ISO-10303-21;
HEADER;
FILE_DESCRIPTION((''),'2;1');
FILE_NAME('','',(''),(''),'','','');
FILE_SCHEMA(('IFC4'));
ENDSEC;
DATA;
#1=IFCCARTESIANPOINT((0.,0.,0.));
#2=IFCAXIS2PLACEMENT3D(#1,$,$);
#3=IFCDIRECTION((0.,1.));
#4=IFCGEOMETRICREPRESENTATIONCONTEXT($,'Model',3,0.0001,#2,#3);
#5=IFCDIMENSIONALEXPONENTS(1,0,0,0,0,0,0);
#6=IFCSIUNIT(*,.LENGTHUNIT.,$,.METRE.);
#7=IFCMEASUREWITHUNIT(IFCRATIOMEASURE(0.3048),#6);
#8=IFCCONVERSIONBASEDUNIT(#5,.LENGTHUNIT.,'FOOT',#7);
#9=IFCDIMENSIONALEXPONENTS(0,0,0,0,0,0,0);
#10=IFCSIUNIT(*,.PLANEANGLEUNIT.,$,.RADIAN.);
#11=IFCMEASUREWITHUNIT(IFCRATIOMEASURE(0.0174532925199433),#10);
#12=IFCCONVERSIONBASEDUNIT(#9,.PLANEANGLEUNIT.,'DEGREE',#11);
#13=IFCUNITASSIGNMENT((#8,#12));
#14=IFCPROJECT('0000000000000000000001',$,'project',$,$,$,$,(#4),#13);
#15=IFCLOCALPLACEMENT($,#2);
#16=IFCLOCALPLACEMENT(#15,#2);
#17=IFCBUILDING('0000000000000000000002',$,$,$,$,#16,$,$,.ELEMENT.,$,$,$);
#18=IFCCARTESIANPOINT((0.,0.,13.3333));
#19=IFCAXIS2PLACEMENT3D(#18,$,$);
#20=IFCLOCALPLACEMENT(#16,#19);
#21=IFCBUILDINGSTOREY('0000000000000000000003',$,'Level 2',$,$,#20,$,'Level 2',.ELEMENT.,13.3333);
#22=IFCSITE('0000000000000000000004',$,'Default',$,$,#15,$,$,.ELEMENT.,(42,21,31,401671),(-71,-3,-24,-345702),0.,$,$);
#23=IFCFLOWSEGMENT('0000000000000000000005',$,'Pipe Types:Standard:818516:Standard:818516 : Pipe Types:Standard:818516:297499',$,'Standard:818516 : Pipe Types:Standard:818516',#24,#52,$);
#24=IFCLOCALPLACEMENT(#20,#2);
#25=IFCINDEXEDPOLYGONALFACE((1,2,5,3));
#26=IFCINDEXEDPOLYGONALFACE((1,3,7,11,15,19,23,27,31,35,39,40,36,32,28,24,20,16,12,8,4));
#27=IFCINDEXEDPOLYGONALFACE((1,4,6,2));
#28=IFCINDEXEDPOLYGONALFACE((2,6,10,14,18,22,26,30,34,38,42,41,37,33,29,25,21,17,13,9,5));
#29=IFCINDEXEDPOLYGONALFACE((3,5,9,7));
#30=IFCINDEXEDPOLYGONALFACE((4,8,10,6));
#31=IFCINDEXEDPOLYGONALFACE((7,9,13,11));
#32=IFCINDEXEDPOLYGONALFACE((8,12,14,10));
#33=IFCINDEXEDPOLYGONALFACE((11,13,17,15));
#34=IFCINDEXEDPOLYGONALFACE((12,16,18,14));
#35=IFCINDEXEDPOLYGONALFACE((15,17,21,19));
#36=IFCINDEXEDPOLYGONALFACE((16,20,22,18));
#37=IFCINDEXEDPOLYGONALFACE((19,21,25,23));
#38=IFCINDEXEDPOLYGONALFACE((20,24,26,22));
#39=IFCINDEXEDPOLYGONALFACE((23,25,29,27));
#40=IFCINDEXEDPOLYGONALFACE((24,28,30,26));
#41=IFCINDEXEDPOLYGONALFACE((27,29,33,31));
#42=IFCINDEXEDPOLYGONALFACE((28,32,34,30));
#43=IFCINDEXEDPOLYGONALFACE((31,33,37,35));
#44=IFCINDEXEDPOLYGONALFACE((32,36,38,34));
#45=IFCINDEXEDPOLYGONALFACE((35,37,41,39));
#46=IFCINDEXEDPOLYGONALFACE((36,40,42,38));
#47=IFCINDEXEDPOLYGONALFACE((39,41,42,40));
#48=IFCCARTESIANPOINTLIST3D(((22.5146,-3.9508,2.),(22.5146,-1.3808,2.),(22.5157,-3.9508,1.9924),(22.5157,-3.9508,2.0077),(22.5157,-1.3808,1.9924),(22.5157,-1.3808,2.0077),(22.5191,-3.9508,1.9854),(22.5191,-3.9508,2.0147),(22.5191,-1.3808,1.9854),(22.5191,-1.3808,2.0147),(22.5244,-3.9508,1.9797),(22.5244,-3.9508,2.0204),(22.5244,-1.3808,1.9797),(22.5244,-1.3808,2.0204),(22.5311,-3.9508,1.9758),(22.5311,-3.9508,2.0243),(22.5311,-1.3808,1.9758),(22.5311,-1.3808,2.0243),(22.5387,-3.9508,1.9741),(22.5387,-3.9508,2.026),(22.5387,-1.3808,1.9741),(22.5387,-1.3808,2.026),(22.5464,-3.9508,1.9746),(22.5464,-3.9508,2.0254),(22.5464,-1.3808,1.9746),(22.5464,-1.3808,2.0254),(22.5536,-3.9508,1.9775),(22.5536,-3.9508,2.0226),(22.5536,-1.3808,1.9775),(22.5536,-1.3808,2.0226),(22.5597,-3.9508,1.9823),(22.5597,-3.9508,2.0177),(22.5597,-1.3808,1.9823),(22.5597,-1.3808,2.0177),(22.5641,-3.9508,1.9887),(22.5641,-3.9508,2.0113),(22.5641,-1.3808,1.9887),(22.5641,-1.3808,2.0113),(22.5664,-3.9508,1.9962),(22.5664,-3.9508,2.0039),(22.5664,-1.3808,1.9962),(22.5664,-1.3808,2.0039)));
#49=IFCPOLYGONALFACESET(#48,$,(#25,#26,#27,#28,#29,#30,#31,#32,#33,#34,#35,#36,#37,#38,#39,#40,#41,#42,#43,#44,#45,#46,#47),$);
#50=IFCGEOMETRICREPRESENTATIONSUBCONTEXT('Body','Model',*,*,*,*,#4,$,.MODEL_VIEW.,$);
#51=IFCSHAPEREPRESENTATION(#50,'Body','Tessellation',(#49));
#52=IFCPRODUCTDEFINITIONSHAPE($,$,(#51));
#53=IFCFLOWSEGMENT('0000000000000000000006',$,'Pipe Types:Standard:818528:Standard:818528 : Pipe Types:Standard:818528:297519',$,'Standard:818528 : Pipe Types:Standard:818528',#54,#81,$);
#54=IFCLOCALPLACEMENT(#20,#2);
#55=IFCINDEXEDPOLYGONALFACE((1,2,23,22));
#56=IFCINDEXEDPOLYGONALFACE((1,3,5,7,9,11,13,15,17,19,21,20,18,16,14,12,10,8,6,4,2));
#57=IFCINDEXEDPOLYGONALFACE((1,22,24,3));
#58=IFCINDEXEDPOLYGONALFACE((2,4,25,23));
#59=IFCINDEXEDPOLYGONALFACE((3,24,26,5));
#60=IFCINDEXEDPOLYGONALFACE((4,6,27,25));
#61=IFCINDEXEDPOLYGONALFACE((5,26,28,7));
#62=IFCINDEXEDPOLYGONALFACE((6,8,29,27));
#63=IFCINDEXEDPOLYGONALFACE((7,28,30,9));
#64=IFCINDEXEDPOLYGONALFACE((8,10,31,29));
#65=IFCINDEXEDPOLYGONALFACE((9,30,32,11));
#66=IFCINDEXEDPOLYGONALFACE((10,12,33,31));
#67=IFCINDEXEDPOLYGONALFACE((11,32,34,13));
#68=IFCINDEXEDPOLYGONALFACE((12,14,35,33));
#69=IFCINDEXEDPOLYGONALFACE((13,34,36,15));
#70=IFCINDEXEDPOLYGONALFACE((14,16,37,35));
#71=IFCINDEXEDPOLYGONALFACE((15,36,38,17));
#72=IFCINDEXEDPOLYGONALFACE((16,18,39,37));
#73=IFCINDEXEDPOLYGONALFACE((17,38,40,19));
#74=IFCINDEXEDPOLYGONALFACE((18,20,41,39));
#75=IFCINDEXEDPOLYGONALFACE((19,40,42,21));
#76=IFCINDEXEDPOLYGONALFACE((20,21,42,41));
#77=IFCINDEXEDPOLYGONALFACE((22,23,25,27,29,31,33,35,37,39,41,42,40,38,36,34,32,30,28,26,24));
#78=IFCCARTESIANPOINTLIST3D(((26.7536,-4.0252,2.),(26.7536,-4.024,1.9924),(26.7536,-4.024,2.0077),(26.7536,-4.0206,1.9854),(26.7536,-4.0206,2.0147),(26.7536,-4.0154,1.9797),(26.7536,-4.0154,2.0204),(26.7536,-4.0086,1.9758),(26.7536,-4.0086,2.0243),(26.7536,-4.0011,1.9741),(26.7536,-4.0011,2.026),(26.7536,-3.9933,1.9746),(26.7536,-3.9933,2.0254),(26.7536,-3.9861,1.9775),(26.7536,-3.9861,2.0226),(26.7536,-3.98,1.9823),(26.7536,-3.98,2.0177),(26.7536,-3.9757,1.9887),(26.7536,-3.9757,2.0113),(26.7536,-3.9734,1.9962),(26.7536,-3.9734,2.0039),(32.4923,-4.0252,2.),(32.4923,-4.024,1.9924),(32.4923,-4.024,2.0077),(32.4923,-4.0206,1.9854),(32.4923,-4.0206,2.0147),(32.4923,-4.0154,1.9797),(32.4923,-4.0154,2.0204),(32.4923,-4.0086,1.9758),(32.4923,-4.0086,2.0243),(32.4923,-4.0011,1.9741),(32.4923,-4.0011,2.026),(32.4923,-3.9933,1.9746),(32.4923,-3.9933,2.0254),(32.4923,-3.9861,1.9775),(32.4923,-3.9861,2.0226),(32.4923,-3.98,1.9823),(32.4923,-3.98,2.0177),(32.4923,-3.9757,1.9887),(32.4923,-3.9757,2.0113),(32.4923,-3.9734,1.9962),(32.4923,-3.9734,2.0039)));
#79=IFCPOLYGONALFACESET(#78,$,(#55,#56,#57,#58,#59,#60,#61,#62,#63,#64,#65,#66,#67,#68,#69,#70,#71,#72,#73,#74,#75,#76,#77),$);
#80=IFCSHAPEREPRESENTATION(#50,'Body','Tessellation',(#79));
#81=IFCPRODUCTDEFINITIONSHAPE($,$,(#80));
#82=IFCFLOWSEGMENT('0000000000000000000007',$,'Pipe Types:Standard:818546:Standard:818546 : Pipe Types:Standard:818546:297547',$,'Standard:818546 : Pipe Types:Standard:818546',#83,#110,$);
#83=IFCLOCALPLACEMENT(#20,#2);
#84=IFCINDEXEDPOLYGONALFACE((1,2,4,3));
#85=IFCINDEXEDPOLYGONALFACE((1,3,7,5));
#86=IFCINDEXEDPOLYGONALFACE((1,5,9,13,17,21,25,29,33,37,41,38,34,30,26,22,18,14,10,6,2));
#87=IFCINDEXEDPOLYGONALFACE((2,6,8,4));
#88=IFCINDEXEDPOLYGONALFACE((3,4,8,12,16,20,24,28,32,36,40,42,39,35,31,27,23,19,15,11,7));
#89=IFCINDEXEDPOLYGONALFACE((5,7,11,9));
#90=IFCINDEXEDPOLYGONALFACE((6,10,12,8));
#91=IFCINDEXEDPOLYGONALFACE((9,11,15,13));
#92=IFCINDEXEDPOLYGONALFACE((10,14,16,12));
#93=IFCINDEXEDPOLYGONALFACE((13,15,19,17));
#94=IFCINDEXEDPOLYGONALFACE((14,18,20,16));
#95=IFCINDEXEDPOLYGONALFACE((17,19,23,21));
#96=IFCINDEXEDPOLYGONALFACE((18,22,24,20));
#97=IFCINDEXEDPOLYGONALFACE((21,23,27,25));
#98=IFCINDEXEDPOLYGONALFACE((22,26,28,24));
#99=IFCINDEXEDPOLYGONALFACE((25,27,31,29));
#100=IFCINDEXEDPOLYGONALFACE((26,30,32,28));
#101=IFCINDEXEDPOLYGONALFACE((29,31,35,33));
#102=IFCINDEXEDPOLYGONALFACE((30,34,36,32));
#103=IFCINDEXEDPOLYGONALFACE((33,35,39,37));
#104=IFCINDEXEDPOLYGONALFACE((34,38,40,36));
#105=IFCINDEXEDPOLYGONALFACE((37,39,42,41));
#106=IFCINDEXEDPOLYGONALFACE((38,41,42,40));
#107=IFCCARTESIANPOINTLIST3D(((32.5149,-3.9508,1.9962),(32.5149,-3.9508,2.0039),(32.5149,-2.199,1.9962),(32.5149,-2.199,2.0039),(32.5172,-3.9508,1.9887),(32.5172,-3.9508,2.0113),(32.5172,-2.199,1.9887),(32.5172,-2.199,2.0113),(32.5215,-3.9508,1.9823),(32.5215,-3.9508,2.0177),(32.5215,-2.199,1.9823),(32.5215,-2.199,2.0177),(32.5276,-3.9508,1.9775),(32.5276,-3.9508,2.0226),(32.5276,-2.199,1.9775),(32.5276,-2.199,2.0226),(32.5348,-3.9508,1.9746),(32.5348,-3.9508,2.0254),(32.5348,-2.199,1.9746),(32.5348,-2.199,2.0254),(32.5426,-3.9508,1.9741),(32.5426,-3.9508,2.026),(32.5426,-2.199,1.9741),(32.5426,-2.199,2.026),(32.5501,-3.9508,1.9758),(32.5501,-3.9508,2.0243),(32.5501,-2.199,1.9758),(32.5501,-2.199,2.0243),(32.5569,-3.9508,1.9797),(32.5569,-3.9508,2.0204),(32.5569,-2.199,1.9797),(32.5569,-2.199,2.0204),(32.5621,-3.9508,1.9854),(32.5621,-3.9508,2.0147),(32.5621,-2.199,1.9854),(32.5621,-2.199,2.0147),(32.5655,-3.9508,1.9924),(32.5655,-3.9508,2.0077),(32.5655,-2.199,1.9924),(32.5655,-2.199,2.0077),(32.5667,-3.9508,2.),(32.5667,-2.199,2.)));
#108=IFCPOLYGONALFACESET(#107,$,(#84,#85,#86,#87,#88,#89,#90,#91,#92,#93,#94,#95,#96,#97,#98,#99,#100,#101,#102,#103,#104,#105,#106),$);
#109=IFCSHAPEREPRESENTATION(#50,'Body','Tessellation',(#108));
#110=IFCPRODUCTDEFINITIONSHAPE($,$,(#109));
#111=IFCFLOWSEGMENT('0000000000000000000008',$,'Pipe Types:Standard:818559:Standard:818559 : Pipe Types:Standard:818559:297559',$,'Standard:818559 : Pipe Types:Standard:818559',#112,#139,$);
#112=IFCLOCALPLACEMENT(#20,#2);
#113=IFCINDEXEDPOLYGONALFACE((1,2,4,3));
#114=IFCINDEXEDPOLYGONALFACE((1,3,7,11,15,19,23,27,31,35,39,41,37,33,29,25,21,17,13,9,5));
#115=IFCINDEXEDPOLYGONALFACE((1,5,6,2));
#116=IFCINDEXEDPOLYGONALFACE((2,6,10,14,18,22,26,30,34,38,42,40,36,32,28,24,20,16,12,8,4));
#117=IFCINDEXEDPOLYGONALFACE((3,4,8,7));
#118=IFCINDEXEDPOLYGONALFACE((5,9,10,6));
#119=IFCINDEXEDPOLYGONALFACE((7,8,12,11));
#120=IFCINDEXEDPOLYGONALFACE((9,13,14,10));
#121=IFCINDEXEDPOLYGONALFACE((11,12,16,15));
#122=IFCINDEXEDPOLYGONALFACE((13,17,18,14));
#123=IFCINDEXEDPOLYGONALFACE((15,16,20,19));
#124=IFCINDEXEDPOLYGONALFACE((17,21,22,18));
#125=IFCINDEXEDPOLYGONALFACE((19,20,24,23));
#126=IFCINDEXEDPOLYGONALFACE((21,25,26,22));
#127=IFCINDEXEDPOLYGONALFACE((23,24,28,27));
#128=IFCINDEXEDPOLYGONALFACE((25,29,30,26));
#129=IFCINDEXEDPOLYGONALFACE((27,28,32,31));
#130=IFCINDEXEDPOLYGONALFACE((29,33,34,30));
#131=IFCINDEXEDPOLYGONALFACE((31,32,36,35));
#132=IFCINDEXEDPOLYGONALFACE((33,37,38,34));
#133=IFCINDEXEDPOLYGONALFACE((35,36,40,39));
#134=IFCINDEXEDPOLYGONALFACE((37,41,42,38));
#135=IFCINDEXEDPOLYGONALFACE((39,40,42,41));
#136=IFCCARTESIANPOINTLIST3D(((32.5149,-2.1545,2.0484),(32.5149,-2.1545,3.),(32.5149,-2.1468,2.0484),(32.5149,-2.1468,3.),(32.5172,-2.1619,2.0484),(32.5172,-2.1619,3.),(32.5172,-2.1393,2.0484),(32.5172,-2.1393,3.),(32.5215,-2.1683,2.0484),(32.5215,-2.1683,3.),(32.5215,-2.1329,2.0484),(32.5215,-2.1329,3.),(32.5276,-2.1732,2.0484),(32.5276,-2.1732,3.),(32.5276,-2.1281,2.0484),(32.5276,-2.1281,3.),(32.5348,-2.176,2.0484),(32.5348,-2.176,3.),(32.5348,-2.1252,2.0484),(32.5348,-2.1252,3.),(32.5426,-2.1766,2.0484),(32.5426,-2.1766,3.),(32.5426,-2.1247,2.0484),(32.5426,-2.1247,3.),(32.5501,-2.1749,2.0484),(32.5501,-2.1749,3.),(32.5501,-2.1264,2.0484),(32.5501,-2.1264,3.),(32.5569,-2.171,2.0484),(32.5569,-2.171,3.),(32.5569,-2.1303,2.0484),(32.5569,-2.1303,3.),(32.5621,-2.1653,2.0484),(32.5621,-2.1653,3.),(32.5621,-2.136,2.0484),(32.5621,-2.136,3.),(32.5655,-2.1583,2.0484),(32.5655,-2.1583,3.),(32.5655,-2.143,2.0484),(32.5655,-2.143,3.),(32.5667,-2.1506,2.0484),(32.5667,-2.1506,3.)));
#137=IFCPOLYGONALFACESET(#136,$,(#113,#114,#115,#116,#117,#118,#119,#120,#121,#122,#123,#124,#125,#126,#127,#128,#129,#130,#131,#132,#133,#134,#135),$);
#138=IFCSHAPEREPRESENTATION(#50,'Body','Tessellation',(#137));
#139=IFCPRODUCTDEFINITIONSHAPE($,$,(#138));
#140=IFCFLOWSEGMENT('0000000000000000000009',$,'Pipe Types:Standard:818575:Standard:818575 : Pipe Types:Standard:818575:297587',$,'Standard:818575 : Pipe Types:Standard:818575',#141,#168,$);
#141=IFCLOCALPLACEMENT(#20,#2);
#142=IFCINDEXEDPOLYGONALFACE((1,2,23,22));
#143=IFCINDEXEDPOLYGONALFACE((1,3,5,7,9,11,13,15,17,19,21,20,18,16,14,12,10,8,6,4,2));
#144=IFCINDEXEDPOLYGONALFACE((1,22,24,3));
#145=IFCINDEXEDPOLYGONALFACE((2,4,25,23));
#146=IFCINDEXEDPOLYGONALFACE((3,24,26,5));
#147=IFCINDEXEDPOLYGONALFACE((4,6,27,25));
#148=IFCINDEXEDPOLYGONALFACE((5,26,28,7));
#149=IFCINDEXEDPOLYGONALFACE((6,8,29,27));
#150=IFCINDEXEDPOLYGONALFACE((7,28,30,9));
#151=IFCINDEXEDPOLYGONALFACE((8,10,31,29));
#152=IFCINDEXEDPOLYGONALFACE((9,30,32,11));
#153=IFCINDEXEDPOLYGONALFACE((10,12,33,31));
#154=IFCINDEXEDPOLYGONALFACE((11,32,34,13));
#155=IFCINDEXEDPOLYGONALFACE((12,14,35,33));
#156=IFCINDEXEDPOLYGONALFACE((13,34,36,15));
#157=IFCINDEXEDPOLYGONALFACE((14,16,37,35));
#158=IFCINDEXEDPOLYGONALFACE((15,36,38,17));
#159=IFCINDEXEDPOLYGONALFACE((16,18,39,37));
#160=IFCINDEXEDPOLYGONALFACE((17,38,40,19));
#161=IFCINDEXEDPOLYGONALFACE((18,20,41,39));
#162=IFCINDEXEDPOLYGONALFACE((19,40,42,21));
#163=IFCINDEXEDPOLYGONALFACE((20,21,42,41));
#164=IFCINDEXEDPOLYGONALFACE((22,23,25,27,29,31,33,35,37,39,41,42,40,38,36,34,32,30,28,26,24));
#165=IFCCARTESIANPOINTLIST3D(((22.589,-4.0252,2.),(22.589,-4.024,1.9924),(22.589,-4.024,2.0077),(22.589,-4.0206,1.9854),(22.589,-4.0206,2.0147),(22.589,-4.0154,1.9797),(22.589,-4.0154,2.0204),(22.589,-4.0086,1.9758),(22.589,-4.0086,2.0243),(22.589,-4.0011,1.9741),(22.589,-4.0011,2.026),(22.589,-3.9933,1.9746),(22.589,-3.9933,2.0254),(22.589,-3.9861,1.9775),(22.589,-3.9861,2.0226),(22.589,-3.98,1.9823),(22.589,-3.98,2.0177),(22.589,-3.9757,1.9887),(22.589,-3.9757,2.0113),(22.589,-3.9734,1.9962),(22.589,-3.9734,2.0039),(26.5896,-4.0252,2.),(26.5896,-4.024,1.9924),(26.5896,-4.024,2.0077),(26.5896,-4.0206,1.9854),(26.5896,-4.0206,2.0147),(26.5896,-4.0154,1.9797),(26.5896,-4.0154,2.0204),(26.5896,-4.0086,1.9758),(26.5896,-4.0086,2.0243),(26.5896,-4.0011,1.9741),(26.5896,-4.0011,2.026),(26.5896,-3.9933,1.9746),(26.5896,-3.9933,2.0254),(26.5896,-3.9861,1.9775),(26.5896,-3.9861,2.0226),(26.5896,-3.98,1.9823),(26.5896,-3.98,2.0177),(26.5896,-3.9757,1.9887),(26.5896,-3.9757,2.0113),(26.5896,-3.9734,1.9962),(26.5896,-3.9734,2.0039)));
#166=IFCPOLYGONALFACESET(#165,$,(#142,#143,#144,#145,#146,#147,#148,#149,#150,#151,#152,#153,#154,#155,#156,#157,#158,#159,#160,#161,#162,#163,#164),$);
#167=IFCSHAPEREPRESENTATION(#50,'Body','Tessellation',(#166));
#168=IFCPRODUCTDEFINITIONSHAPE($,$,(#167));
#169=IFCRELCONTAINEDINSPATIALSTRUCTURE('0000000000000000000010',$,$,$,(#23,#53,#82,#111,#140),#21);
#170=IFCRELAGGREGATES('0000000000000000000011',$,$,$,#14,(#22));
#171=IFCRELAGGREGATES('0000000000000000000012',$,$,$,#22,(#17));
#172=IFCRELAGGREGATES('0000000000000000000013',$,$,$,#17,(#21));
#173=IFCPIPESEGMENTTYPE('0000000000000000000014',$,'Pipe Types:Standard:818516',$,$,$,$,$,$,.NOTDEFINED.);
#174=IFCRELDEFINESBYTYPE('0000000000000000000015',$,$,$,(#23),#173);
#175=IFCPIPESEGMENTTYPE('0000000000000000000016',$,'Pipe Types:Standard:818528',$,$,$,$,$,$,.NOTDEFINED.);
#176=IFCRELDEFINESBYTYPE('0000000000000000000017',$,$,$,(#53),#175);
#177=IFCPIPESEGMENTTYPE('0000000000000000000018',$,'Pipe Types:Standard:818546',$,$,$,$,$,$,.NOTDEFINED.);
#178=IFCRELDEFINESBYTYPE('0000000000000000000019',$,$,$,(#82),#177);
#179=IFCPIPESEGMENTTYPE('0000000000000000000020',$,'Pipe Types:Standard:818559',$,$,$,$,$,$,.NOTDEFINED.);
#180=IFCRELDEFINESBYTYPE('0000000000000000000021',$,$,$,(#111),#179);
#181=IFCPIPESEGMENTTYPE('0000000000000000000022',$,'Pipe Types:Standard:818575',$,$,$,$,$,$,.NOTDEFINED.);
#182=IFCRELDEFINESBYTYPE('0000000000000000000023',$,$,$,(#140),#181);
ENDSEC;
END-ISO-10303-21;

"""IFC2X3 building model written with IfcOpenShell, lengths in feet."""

from ifc_helpers import new_model, entity, si_unit, converted_unit, direction, frame, origin, origin_2d_with_axis, place, context, subcontext, project, spatial, circle, extrude, source, transform, mapped, type_object, type_shapes, element, save


model = new_model("IFC2X3")

# Units and contexts
model_context = context("Model", 3, precision=0.0001, world=origin(), true_north=direction((0.0, 1.0)))
body_context = subcontext(model_context, "Body", "Model", "MODEL_VIEW")
ifc_project = project(units=[converted_unit("LENGTHUNIT", "FOOT", entity("IfcRatioMeasure", 0.3048), si_unit("LENGTHUNIT", "METRE"), dimensions=[1, 0, 0, 0, 0, 0, 0]), converted_unit("PLANEANGLEUNIT", "DEGREE", entity("IfcRatioMeasure", 0.0174532925199433), si_unit("PLANEANGLEUNIT", "RADIAN"), dimensions=[0, 0, 0, 0, 0, 0, 0])], contexts=[model_context])

# Site, building, storey
site_placement = place(None, origin())
site = spatial("IfcSite", under=ifc_project, at=site_placement, Name="Default", CompositionType="ELEMENT", RefLatitude=(42, 21, 31, 401671), RefLongitude=(-71, -3, -24, -345702), RefElevation=0.0)
building_placement = place(site_placement, origin())
building = spatial("IfcBuilding", under=site, at=building_placement, CompositionType="ELEMENT")
storey_placement = place(building_placement, frame((0.0, 0.0, 13.3333)))
storey = spatial("IfcBuildingStorey", under=building, at=storey_placement, Name="Level 2", LongName="Level 2", CompositionType="ELEMENT", Elevation=13.3333)

# Flow segments
pipe_segment_type_1 = type_object("IfcPipeSegmentType", Name="Pipe Types:Standard:818516", PredefinedType="NOTDEFINED")
shared_shape_1 = source(origin(), body_context, "Body", "SweptSolid", [
    extrude(circle(Radius=0.026, at=origin_2d_with_axis()), frame((22.5406, -3.9508, 15.3333), z_axis=(0.0, 1.0, 0.0), x_axis=(-1.0, 0.0, 0.0)), (0.0, 0.0, 1.0), 2.57),
])
type_shapes(pipe_segment_type_1, [shared_shape_1])
flow_segment_1_placement = place(building_placement, origin())
element("IfcFlowSegment", 1, at=flow_segment_1_placement, inside=storey, type_object=pipe_segment_type_1, Name="Pipe Types:Standard:818516:Standard:818516 : Pipe Types:Standard:818516:297499", ObjectType="Standard:818516 : Pipe Types:Standard:818516", context=body_context, shape_type="MappedRepresentation", body=[
    mapped(shared_shape_1, transform((0.0, 0.0, 0.0), scale=1.0)),
])
pipe_segment_type_2 = type_object("IfcPipeSegmentType", Name="Pipe Types:Standard:818528", PredefinedType="NOTDEFINED")
shared_shape_2 = source(origin(), body_context, "Body", "SweptSolid", [
    extrude(circle(Radius=0.026, at=origin_2d_with_axis()), frame((26.7536, -3.9991, 15.3333), z_axis=(1.0, 0.0, 0.0), x_axis=(0.0, -1.0, 0.0)), (0.0, 0.0, 1.0), 5.7387),
])
type_shapes(pipe_segment_type_2, [shared_shape_2])
flow_segment_2_placement = place(building_placement, origin())
element("IfcFlowSegment", 2, at=flow_segment_2_placement, inside=storey, type_object=pipe_segment_type_2, Name="Pipe Types:Standard:818528:Standard:818528 : Pipe Types:Standard:818528:297519", ObjectType="Standard:818528 : Pipe Types:Standard:818528", context=body_context, shape_type="MappedRepresentation", body=[
    mapped(shared_shape_2, transform((0.0, 0.0, 0.0), scale=1.0)),
])
pipe_segment_type_3 = type_object("IfcPipeSegmentType", Name="Pipe Types:Standard:818546", PredefinedType="NOTDEFINED")
shared_shape_3 = source(origin(), body_context, "Body", "SweptSolid", [
    extrude(circle(Radius=0.026, at=origin_2d_with_axis()), frame((32.5406, -3.9508, 15.3333), z_axis=(0.0, 1.0, 0.0), x_axis=(1.0, 0.0, 0.0)), (0.0, 0.0, 1.0), 1.7518),
])
type_shapes(pipe_segment_type_3, [shared_shape_3])
flow_segment_3_placement = place(building_placement, origin())
element("IfcFlowSegment", 3, at=flow_segment_3_placement, inside=storey, type_object=pipe_segment_type_3, Name="Pipe Types:Standard:818546:Standard:818546 : Pipe Types:Standard:818546:297547", ObjectType="Standard:818546 : Pipe Types:Standard:818546", context=body_context, shape_type="MappedRepresentation", body=[
    mapped(shared_shape_3, transform((0.0, 0.0, 0.0), scale=1.0)),
])
pipe_segment_type_4 = type_object("IfcPipeSegmentType", Name="Pipe Types:Standard:818559", PredefinedType="NOTDEFINED")
shared_shape_4 = source(origin(), body_context, "Body", "SweptSolid", [
    extrude(circle(Radius=0.026, at=origin_2d_with_axis()), frame((32.5406, -2.1506, 15.3817)), (0.0, 0.0, 1.0), 0.9517),
])
type_shapes(pipe_segment_type_4, [shared_shape_4])
flow_segment_4_placement = place(building_placement, origin())
element("IfcFlowSegment", 4, at=flow_segment_4_placement, inside=storey, type_object=pipe_segment_type_4, Name="Pipe Types:Standard:818559:Standard:818559 : Pipe Types:Standard:818559:297559", ObjectType="Standard:818559 : Pipe Types:Standard:818559", context=body_context, shape_type="MappedRepresentation", body=[
    mapped(shared_shape_4, transform((0.0, 0.0, 0.0), scale=1.0)),
])
pipe_segment_type_5 = type_object("IfcPipeSegmentType", Name="Pipe Types:Standard:818575", PredefinedType="NOTDEFINED")
shared_shape_5 = source(origin(), body_context, "Body", "SweptSolid", [
    extrude(circle(Radius=0.026, at=origin_2d_with_axis()), frame((22.589, -3.9991, 15.3333), z_axis=(1.0, 0.0, 0.0), x_axis=(0.0, -1.0, 0.0)), (0.0, 0.0, 1.0), 4.0006),
])
type_shapes(pipe_segment_type_5, [shared_shape_5])
flow_segment_5_placement = place(building_placement, origin())
element("IfcFlowSegment", 5, at=flow_segment_5_placement, inside=storey, type_object=pipe_segment_type_5, Name="Pipe Types:Standard:818575:Standard:818575 : Pipe Types:Standard:818575:297587", ObjectType="Standard:818575 : Pipe Types:Standard:818575", context=body_context, shape_type="MappedRepresentation", body=[
    mapped(shared_shape_5, transform((0.0, 0.0, 0.0), scale=1.0)),
])

save(model, "model.ifc")
